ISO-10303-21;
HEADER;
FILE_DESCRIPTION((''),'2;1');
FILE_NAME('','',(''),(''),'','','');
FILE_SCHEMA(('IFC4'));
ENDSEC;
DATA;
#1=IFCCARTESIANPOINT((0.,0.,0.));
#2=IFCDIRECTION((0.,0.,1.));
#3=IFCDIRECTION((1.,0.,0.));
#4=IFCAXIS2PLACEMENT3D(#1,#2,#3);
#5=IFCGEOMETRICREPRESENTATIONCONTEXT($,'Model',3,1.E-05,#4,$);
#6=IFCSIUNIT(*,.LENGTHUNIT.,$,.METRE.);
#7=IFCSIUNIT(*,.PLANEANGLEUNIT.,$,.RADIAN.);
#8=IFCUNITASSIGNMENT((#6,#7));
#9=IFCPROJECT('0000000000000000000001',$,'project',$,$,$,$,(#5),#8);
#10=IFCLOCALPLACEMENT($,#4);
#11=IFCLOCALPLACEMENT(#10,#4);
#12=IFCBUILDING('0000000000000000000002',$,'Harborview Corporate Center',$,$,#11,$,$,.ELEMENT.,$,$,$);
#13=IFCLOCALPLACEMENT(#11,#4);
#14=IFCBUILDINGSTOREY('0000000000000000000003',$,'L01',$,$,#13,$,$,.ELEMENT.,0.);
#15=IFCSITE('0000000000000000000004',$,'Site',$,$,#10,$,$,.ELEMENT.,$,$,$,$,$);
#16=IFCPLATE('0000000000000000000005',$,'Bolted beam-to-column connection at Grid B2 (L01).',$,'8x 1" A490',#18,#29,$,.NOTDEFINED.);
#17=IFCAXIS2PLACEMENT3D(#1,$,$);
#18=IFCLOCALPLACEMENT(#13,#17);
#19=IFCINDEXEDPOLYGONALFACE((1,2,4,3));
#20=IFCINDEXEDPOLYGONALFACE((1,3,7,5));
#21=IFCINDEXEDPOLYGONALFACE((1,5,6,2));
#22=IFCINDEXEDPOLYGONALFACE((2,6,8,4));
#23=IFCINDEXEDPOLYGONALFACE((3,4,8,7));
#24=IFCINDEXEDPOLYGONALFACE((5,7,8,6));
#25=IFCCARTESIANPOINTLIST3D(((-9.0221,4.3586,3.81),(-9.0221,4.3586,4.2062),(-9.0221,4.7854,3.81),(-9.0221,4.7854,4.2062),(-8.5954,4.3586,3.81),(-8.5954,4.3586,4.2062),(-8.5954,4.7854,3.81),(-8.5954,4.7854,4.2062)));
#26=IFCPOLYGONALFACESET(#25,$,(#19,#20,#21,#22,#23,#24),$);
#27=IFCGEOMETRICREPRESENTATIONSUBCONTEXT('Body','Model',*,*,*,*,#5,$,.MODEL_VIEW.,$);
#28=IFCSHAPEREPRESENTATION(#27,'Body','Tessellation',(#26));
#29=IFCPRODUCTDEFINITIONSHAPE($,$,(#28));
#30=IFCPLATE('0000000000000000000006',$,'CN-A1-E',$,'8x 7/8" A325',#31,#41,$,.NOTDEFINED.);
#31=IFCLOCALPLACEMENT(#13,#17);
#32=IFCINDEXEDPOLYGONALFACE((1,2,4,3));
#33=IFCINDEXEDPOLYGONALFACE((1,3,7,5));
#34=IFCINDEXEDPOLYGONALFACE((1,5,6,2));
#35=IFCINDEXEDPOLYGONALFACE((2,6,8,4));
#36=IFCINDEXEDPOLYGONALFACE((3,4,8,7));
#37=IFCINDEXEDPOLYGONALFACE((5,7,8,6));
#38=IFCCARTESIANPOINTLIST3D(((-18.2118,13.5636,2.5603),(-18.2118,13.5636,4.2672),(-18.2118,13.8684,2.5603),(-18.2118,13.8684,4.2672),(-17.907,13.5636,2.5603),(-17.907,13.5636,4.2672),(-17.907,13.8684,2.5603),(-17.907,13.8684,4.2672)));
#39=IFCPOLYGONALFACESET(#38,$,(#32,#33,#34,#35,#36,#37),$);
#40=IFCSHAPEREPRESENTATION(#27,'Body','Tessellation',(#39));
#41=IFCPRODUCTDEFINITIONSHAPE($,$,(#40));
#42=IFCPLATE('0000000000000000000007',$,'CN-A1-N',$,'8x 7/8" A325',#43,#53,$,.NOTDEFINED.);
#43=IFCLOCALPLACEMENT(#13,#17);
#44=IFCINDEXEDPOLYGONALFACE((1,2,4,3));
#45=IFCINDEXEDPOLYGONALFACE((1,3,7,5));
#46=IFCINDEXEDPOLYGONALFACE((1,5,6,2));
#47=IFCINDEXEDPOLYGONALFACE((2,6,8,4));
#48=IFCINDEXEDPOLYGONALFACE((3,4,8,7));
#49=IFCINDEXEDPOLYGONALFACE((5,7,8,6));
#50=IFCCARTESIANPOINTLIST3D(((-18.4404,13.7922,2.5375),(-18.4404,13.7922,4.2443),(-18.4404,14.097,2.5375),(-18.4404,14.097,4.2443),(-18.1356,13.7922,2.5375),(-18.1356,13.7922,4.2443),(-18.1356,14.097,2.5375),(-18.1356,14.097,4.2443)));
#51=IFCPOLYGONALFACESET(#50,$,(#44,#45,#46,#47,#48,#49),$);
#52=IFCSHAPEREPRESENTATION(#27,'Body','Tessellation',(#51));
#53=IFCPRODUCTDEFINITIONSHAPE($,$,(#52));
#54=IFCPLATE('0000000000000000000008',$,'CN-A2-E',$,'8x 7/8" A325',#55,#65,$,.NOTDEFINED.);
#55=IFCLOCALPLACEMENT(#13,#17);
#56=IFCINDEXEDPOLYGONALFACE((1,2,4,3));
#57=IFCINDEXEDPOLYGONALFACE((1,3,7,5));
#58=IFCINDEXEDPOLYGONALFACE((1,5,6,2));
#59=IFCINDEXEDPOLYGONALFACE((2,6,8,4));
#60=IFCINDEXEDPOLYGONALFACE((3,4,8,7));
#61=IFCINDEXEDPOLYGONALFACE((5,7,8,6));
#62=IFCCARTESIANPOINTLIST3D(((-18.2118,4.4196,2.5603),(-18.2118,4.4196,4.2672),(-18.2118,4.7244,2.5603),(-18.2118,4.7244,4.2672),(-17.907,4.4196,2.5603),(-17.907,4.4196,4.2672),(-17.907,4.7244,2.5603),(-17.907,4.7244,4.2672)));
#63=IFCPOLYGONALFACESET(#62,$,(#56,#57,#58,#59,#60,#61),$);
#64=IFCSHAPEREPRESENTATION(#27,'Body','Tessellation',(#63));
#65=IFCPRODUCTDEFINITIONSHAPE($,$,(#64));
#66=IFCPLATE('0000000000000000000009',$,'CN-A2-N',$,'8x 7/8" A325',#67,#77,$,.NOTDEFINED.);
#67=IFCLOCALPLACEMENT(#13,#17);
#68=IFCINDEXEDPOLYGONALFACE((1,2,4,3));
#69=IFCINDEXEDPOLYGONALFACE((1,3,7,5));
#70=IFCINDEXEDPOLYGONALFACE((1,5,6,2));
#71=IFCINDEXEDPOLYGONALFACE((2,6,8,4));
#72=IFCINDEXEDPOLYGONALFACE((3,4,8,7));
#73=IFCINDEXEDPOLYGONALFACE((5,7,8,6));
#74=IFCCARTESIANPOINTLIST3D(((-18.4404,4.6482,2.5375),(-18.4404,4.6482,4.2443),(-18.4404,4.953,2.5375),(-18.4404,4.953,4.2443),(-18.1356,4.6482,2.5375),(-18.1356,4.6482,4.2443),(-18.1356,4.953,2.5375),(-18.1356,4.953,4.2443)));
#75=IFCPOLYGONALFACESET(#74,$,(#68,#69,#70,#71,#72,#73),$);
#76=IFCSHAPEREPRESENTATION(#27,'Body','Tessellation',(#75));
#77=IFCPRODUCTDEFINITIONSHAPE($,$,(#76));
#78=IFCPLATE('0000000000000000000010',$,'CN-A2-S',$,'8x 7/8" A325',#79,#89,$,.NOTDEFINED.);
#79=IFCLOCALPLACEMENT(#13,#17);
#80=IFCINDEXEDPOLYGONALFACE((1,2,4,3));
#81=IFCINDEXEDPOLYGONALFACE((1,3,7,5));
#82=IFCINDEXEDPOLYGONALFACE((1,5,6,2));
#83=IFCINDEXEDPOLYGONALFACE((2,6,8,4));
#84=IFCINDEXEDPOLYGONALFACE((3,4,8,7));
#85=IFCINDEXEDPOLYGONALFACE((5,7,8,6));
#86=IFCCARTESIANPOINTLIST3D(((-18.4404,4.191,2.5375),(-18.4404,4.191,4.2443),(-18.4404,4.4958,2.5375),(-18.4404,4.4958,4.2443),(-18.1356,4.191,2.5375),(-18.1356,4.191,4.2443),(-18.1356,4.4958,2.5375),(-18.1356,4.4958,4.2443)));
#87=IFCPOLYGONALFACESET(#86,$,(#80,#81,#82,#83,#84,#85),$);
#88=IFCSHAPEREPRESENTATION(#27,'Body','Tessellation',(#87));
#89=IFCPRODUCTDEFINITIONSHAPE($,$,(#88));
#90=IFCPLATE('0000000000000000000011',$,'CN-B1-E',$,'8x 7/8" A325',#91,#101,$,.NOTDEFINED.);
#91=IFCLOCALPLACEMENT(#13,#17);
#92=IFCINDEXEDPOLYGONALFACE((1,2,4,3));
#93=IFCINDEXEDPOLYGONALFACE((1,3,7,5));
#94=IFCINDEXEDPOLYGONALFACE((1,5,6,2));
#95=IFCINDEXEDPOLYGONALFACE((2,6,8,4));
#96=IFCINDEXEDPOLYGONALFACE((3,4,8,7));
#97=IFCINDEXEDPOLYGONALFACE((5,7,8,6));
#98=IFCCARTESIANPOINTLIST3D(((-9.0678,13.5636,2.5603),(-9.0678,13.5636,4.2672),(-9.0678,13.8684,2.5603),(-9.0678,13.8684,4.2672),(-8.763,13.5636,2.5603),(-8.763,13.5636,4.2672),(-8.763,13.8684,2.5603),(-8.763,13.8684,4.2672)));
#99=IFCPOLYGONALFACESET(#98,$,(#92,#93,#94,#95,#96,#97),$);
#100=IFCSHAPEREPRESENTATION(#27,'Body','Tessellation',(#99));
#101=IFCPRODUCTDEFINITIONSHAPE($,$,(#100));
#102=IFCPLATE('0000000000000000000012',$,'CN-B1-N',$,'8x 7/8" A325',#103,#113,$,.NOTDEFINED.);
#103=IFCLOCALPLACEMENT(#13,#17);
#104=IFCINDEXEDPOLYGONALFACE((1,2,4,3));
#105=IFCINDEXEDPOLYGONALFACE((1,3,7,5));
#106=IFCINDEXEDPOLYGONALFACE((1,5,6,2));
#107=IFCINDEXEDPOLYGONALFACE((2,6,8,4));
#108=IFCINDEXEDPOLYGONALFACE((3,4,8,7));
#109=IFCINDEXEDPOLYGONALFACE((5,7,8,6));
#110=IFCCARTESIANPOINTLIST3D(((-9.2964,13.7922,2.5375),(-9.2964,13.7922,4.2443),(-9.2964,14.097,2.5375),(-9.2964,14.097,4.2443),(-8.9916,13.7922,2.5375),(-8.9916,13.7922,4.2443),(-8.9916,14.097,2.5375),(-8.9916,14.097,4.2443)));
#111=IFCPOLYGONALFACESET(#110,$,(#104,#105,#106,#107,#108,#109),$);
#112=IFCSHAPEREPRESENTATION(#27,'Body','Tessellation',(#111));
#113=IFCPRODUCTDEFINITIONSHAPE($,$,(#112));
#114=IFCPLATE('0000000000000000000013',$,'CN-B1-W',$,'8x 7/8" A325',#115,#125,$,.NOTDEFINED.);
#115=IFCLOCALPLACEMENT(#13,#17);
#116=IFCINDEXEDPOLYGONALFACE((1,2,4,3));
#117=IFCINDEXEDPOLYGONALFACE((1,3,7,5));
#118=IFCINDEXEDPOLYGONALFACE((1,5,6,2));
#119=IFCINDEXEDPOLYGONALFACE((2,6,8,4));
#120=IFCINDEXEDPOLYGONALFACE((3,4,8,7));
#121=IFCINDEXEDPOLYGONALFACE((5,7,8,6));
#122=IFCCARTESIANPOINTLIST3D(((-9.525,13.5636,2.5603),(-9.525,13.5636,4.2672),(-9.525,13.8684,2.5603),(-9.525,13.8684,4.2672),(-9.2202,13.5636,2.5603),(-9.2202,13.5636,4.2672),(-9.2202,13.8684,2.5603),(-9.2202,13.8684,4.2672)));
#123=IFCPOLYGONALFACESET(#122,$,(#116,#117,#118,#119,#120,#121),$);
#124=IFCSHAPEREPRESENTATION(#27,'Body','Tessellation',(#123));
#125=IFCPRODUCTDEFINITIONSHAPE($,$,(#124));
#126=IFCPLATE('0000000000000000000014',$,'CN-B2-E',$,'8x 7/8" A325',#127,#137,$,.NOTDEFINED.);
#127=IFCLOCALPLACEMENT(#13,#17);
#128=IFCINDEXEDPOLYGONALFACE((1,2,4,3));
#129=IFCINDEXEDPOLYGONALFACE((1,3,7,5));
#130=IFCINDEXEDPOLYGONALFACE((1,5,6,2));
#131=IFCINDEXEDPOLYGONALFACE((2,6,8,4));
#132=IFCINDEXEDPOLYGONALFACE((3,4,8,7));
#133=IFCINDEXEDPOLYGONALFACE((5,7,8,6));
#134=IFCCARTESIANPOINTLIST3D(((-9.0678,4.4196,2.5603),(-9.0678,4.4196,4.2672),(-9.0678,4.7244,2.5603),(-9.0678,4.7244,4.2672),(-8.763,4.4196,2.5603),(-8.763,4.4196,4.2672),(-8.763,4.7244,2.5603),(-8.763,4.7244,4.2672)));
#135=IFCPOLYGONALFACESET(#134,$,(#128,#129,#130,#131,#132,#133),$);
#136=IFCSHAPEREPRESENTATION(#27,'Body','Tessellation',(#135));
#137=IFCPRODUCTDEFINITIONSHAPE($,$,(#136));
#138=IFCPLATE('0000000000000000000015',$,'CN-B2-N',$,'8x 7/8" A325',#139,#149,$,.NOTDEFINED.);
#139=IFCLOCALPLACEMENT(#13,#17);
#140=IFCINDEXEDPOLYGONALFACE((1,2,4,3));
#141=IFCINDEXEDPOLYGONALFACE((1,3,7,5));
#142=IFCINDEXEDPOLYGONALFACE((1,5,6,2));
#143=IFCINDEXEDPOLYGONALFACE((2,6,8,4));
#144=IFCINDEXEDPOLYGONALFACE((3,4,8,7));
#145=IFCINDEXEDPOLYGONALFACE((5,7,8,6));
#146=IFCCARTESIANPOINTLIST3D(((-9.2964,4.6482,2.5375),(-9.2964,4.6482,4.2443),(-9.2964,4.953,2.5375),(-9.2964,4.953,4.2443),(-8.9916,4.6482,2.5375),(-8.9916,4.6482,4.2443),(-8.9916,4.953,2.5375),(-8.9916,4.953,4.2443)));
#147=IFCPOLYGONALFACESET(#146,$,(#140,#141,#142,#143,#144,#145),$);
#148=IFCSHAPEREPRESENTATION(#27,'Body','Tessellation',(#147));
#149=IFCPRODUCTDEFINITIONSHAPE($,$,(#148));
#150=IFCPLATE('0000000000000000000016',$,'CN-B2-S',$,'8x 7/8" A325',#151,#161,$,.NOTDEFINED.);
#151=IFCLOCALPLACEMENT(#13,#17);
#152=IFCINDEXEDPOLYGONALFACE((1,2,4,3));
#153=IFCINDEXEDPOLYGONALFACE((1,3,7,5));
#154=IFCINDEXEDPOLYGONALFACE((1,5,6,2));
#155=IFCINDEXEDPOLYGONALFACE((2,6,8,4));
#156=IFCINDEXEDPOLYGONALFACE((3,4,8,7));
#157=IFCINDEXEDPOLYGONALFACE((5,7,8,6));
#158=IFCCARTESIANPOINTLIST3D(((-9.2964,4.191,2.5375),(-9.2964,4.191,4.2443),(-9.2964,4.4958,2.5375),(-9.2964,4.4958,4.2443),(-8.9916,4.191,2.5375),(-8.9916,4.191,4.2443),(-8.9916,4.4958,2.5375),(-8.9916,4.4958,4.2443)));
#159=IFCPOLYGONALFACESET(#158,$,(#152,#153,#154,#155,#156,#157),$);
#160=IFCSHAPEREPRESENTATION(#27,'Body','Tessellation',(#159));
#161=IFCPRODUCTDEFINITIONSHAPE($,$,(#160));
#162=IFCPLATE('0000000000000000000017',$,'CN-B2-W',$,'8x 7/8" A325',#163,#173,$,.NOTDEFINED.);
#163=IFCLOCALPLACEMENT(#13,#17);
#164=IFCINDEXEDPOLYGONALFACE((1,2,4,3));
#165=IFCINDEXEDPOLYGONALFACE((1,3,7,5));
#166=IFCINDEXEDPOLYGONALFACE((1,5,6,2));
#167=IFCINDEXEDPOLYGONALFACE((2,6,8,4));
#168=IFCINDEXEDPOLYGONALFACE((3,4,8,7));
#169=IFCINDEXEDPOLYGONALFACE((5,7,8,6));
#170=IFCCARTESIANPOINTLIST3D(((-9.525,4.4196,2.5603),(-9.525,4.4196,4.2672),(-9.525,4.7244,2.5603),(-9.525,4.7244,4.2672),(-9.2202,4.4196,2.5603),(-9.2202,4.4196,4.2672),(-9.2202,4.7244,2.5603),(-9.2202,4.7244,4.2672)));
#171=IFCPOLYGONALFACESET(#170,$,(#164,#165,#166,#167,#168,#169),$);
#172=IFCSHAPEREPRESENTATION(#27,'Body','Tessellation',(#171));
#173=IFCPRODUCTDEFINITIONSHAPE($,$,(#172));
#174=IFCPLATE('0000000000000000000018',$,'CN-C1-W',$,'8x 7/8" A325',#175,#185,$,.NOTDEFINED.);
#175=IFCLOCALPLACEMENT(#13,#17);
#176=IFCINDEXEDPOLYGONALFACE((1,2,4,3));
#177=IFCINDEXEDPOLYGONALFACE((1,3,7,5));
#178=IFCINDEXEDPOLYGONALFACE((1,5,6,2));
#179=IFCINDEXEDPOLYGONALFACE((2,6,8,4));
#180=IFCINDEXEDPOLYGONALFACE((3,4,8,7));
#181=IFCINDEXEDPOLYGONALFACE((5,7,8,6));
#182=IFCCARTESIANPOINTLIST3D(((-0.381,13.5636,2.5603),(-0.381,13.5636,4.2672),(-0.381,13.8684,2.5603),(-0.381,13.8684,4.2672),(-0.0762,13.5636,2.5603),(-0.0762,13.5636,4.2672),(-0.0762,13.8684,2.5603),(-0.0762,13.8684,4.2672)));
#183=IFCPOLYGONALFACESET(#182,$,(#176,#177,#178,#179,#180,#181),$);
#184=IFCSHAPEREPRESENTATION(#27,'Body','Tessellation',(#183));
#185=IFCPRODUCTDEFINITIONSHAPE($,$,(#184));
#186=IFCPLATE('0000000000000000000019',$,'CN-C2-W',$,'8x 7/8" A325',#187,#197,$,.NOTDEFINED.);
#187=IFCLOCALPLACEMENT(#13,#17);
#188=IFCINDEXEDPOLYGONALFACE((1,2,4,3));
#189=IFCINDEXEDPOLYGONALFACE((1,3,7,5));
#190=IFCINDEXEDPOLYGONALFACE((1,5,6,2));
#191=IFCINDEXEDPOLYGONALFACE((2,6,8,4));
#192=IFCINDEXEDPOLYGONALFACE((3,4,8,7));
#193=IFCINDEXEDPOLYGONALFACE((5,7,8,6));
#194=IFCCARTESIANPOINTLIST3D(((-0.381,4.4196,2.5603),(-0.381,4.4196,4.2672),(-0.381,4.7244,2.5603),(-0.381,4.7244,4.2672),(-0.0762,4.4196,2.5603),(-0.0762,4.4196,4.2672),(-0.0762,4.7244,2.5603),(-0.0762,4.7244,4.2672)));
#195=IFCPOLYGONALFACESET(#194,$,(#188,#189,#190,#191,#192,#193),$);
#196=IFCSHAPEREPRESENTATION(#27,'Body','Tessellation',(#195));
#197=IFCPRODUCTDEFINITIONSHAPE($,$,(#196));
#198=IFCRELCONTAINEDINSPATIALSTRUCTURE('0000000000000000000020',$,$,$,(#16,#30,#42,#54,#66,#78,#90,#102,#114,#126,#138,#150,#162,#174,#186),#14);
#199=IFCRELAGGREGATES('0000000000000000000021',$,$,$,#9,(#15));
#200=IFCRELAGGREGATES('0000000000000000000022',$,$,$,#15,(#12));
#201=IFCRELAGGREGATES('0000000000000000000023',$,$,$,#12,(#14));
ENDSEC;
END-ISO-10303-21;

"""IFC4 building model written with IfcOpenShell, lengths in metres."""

from ifc_helpers import new_model, si_unit, frame, origin_with_axes, place, context, subcontext, project, spatial, rectangle, extrude, element, save


model = new_model("IFC4")

# Units and contexts
model_context = context("Model", 3, precision=1e-05, world=origin_with_axes())
body_context = subcontext(model_context, "Body", "Model", "MODEL_VIEW")
ifc_project = project(units=[si_unit("LENGTHUNIT", "METRE"), si_unit("PLANEANGLEUNIT", "RADIAN")], contexts=[model_context])

# Site, building, storey
site_placement = place(None, origin_with_axes())
site = spatial("IfcSite", under=ifc_project, at=site_placement, Name="Site", CompositionType="ELEMENT")
building_placement = place(site_placement, origin_with_axes())
building = spatial("IfcBuilding", under=site, at=building_placement, Name="Harborview Corporate Center", CompositionType="ELEMENT")
storey_placement = place(building_placement, origin_with_axes())
storey = spatial("IfcBuildingStorey", under=building, at=storey_placement, Name="L01", CompositionType="ELEMENT", Elevation=0.0)

# Plates
plate_1_placement = place(storey_placement, frame((-8.8087, 4.572, 3.81), z_axis=(0.0, 0.0, 1.0), x_axis=(1.0, 0.0, 0.0)))
element("IfcPlate", 1, at=plate_1_placement, inside=storey, Name="Bolted beam-to-column connection at Grid B2 (L01).", ObjectType="8x 1\" A490", PredefinedType="NOTDEFINED", context=body_context, shape_type="SweptSolid", body=[
    extrude(rectangle(XDim=0.4267, YDim=0.4267), origin_with_axes(), (0.0, 0.0, 1.0), 0.3962),
])
for number, where, z_axis, x_axis, name in (
    (2, (-18.0594, 13.716, 2.5603), (0.0, 0.0, 1.0), (1.0, 0.0, 0.0), "CN-A1-E"),
    (3, (-18.288, 13.9446, 2.5375), (0.0, 0.0, 1.0), (1.0, 0.0, 0.0), "CN-A1-N"),
    (4, (-18.0594, 4.572, 2.5603), (0.0, 0.0, 1.0), (1.0, 0.0, 0.0), "CN-A2-E"),
    (5, (-18.288, 4.8006, 2.5375), (0.0, 0.0, 1.0), (1.0, 0.0, 0.0), "CN-A2-N"),
    (6, (-18.288, 4.3434, 2.5375), (0.0, 0.0, 1.0), (1.0, 0.0, 0.0), "CN-A2-S"),
    (7, (-8.9154, 13.716, 2.5603), (0.0, 0.0, 1.0), (1.0, 0.0, 0.0), "CN-B1-E"),
    (8, (-9.144, 13.9446, 2.5375), (0.0, 0.0, 1.0), (1.0, 0.0, 0.0), "CN-B1-N"),
    (9, (-9.3726, 13.716, 2.5603), (0.0, 0.0, 1.0), (1.0, 0.0, 0.0), "CN-B1-W"),
    (10, (-8.9154, 4.572, 2.5603), (0.0, 0.0, 1.0), (1.0, 0.0, 0.0), "CN-B2-E"),
    (11, (-9.144, 4.8006, 2.5375), (0.0, 0.0, 1.0), (1.0, 0.0, 0.0), "CN-B2-N"),
    (12, (-9.144, 4.3434, 2.5375), (0.0, 0.0, 1.0), (1.0, 0.0, 0.0), "CN-B2-S"),
    (13, (-9.3726, 4.572, 2.5603), (0.0, 0.0, 1.0), (1.0, 0.0, 0.0), "CN-B2-W"),
):
    element("IfcPlate", number, at=place(storey_placement, frame(where, z_axis=z_axis, x_axis=x_axis)), inside=storey, Name=name, ObjectType="8x 7/8\" A325", PredefinedType="NOTDEFINED", context=body_context, shape_type="SweptSolid", body=[
        extrude(rectangle(XDim=0.3048, YDim=0.3048), origin_with_axes(), (0.0, 0.0, 1.0), 1.7069),
    ])
for number, where, z_axis, x_axis, name in (
    (14, (-0.2286, 13.716, 2.5603), (0.0, 0.0, 1.0), (1.0, 0.0, 0.0), "CN-C1-W"),
    (15, (-0.2286, 4.572, 2.5603), (0.0, 0.0, 1.0), (1.0, 0.0, 0.0), "CN-C2-W"),
):
    element("IfcPlate", number, at=place(storey_placement, frame(where, z_axis=z_axis, x_axis=x_axis)), inside=storey, Name=name, ObjectType="8x 7/8\" A325", PredefinedType="NOTDEFINED", context=body_context, shape_type="SweptSolid", body=[
        extrude(rectangle(XDim=0.3048, YDim=0.3048), origin_with_axes(), (0.0, 0.0, 1.0), 1.7069),
    ])

save(model, "model.ifc")
